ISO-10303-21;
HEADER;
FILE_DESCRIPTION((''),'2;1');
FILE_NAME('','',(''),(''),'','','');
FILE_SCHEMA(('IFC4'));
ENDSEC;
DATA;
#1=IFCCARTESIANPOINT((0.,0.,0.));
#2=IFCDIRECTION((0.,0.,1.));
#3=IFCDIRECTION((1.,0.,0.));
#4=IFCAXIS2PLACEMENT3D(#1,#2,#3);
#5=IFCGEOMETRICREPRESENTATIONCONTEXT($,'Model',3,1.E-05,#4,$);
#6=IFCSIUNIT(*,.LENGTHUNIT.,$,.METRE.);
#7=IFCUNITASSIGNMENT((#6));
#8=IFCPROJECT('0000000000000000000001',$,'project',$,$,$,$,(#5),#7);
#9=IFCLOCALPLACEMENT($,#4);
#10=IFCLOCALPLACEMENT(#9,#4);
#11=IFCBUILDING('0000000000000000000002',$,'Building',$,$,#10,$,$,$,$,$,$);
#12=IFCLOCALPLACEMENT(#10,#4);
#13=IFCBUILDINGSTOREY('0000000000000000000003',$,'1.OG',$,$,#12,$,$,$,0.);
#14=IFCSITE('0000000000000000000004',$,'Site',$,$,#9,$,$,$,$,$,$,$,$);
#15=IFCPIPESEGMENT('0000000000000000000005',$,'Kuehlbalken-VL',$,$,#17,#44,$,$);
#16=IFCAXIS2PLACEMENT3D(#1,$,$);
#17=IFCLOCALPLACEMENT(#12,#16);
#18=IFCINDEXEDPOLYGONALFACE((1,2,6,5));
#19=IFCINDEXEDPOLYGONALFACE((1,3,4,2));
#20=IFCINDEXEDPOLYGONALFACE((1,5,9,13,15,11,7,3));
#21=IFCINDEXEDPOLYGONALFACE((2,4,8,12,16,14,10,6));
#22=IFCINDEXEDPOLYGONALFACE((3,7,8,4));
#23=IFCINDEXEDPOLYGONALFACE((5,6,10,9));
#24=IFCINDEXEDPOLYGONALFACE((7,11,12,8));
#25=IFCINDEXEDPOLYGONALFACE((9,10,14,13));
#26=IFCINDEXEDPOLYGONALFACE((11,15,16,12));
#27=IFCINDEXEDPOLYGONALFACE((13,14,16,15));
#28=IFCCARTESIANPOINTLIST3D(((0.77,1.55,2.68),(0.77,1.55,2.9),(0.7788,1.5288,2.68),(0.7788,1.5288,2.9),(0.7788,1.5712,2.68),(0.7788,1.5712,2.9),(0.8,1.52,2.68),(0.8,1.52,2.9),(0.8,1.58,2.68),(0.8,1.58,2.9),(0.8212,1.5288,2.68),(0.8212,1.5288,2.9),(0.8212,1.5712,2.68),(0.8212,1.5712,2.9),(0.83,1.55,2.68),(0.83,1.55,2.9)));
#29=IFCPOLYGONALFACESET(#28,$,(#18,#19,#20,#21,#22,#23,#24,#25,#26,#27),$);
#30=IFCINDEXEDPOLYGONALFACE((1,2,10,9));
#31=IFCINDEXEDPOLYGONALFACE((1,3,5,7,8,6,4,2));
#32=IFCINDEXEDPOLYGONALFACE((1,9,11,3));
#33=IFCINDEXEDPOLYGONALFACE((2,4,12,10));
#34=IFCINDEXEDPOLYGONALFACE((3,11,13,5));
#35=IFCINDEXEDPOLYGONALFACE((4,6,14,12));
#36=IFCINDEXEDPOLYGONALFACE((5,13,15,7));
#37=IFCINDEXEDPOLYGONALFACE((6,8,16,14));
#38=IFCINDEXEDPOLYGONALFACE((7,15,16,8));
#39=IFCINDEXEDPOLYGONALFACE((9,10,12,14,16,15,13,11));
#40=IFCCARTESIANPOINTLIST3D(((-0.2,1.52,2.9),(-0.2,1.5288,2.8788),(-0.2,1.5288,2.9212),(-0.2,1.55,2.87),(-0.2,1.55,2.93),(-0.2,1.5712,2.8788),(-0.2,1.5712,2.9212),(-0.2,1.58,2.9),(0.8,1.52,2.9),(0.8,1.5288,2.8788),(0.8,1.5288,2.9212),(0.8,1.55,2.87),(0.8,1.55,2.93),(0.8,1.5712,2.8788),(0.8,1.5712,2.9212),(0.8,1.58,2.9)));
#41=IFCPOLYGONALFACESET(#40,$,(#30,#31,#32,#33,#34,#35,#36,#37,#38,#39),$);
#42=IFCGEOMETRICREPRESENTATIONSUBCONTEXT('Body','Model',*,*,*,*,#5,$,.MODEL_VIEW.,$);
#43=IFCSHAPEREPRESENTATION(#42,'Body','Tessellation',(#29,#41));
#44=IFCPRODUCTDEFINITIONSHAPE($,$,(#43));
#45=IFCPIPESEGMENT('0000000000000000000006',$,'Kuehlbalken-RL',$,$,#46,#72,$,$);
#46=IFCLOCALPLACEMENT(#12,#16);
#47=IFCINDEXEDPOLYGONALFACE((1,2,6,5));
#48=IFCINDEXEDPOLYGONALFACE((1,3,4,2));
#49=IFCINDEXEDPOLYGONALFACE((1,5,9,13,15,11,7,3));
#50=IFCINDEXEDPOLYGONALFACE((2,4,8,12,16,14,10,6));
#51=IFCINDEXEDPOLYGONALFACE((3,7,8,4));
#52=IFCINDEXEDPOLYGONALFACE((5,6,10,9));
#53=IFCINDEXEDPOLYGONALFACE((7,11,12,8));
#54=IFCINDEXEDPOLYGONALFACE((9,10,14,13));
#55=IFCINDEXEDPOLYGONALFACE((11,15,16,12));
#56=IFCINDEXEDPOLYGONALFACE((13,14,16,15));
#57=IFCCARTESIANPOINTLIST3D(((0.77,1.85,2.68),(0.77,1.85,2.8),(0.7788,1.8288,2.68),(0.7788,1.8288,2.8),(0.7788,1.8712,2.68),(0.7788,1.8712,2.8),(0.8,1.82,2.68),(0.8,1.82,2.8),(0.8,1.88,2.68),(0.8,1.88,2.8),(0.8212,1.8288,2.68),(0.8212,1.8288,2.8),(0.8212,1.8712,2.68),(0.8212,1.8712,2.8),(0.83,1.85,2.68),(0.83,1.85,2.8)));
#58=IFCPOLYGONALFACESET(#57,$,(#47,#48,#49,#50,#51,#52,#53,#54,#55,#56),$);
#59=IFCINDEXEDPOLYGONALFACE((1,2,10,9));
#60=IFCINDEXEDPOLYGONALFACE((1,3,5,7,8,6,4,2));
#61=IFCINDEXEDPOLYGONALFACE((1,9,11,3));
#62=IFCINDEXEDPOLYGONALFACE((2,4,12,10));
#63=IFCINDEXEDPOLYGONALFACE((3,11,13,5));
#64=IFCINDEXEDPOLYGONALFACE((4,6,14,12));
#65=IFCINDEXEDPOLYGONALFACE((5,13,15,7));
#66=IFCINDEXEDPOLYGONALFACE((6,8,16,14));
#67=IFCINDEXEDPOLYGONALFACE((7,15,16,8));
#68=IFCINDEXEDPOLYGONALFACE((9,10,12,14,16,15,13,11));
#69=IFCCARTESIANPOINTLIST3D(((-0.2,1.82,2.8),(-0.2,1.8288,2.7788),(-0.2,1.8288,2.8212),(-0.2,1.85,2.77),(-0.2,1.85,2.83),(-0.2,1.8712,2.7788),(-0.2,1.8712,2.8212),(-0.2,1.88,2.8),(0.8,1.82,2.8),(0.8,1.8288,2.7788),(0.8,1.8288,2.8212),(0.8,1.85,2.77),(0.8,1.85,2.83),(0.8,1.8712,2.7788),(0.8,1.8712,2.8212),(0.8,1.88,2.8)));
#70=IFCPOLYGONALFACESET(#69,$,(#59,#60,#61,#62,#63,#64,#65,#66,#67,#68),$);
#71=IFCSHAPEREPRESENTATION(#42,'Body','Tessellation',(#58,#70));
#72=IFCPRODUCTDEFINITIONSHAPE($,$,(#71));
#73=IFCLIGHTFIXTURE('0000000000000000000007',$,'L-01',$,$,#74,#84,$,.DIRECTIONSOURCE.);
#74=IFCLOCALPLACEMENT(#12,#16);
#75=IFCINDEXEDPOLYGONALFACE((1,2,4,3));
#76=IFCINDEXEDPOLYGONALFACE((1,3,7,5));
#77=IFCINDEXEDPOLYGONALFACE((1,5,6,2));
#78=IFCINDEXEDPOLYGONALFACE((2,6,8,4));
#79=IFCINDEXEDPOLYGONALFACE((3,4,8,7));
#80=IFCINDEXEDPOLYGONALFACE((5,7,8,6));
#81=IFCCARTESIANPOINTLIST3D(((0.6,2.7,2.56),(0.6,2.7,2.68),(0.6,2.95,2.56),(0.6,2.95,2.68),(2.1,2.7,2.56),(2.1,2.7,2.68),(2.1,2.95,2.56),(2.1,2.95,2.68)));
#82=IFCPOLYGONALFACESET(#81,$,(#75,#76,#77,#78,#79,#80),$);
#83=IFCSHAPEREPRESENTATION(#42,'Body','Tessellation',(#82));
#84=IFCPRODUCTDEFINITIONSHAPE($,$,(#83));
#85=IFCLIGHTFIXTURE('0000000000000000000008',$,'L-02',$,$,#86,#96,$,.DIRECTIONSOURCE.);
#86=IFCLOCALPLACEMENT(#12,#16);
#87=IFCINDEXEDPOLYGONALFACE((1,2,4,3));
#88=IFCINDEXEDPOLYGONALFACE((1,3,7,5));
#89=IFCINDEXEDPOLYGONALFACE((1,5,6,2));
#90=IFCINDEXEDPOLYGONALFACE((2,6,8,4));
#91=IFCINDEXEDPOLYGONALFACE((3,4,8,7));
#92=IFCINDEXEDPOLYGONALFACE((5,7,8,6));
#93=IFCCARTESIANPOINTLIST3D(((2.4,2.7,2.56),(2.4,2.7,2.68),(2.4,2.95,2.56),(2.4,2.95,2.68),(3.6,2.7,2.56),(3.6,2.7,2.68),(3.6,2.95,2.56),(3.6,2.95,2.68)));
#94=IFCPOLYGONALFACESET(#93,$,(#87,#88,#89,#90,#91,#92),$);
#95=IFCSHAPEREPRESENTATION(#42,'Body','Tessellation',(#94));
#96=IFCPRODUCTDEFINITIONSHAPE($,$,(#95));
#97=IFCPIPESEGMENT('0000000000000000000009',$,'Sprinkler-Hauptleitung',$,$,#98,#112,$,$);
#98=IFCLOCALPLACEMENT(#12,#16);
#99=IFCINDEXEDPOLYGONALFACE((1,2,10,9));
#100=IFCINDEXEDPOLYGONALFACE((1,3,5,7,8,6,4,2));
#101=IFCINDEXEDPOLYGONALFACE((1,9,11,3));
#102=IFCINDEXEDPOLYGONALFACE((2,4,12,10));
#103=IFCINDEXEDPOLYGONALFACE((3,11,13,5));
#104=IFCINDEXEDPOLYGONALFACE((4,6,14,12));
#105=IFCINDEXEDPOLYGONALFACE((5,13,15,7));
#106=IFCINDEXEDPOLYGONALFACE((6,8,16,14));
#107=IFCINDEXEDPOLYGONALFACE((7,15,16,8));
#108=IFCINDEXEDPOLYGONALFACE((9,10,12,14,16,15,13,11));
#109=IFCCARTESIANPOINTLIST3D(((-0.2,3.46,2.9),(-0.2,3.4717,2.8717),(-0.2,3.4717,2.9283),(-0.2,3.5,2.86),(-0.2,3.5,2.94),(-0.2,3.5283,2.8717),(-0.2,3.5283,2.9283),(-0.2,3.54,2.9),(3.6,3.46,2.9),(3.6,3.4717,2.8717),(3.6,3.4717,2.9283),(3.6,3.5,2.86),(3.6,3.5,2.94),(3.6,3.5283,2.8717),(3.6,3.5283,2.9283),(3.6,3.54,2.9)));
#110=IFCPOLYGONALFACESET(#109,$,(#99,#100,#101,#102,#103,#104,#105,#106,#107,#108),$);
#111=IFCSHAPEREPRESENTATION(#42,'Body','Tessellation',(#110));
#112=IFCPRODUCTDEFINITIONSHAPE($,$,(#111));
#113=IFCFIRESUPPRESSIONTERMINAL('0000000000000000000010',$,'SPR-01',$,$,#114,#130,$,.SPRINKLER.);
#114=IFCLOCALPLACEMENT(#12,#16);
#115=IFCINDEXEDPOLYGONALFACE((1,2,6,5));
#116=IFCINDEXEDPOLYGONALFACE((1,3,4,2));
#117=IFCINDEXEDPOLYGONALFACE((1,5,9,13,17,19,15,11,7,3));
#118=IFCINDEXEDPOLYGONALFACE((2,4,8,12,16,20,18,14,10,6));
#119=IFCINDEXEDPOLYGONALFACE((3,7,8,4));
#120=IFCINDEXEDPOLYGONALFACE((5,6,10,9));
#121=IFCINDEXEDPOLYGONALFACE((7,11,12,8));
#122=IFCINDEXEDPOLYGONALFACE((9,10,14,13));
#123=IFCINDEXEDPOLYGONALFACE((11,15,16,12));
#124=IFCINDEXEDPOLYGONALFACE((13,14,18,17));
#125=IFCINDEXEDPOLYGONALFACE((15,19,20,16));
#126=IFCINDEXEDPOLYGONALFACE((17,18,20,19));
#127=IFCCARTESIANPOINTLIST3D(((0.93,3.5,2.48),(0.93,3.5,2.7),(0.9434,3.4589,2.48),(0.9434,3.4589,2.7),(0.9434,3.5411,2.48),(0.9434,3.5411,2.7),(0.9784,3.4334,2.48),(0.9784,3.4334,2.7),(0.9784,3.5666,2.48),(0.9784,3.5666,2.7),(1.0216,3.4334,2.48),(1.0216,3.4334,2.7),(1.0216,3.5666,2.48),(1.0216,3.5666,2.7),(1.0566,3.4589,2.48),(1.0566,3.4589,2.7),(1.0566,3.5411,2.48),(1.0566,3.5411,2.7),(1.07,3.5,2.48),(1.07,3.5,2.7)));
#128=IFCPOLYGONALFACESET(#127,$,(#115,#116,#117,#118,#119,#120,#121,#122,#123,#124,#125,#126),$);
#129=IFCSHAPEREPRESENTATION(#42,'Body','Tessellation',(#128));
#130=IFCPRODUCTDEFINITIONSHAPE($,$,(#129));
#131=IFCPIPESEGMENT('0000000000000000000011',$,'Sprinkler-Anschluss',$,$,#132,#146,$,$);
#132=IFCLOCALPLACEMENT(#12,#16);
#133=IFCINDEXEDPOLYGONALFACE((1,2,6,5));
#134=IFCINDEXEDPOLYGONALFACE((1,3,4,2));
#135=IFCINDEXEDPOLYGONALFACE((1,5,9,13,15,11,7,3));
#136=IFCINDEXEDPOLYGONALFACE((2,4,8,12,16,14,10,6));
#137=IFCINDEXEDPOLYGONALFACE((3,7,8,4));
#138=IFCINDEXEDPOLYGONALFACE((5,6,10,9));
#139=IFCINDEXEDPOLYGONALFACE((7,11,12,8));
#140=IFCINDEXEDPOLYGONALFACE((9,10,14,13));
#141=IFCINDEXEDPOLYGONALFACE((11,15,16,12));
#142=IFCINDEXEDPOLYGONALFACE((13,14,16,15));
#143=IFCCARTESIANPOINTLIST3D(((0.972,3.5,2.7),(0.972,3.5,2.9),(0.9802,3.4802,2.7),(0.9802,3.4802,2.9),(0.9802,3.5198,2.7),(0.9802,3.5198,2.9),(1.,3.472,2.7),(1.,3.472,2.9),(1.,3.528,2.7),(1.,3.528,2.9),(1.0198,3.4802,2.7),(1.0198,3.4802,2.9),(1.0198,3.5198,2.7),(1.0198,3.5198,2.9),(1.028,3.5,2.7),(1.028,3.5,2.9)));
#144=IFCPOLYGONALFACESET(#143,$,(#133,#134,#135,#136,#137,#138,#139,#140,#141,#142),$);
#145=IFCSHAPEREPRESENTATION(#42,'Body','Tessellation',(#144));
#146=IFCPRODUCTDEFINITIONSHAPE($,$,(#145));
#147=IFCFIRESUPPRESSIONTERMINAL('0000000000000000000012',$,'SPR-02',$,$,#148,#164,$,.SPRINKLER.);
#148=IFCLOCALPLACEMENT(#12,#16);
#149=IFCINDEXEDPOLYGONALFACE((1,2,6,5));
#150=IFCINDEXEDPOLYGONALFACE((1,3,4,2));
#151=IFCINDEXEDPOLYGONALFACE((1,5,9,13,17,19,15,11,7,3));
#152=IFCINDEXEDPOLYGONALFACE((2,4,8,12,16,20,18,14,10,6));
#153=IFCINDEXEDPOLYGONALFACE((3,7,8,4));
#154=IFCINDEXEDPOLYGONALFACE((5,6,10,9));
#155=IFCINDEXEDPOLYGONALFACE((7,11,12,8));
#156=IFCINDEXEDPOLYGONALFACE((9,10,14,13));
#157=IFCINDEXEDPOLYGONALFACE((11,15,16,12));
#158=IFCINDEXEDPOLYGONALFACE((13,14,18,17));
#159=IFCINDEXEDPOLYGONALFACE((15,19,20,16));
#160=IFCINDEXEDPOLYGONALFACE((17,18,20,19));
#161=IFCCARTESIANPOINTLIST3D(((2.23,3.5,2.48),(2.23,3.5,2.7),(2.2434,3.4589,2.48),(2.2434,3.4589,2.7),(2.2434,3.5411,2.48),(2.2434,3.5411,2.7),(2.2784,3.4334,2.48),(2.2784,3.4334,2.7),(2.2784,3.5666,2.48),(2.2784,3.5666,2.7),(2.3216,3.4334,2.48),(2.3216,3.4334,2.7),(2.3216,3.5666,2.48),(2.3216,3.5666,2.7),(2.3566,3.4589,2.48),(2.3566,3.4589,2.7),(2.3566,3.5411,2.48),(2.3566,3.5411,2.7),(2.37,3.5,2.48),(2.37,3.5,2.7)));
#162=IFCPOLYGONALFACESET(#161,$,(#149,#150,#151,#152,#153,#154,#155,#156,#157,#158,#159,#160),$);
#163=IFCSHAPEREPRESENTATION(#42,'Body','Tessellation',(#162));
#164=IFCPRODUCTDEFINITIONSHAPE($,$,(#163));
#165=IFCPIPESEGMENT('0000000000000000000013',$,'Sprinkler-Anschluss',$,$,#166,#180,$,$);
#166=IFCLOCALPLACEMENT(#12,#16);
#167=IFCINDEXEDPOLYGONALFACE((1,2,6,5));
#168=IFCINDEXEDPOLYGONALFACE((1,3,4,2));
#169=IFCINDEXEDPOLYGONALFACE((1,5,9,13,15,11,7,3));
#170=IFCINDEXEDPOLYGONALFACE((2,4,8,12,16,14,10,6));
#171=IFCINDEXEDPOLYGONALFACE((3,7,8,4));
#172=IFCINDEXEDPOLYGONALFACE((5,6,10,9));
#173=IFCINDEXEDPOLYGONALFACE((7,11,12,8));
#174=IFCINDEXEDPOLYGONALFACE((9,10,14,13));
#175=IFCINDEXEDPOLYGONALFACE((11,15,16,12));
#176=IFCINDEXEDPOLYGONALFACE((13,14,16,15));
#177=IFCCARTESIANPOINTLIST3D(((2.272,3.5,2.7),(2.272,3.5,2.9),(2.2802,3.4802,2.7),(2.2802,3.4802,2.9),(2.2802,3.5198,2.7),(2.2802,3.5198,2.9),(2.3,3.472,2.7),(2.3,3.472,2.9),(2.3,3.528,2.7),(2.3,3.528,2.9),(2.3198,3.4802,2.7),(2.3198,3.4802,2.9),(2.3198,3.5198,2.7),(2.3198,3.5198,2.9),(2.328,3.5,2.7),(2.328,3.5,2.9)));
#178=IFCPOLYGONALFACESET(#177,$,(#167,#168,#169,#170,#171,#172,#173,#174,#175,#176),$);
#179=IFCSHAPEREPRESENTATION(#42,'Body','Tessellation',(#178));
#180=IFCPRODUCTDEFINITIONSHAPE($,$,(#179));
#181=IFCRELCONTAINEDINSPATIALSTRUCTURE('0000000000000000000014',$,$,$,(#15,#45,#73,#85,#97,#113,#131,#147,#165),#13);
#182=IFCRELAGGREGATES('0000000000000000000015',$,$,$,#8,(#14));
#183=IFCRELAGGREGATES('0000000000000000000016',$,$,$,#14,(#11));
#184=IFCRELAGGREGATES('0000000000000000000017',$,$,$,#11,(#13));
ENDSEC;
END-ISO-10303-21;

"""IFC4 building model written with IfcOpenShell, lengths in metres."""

from ifc_helpers import new_model, si_unit, frame, origin_with_axes, place, context, subcontext, project, spatial, polyline, outline, extrude, element, save


model = new_model("IFC4")

# Units and contexts
model_context = context("Model", 3, precision=1e-05, world=origin_with_axes())
body_context = subcontext(model_context, "Body", "Model", "MODEL_VIEW")
ifc_project = project(units=[si_unit("LENGTHUNIT", "METRE")], contexts=[model_context])

# Site, building, storey
site_placement = place(None, origin_with_axes())
site = spatial("IfcSite", under=ifc_project, at=site_placement, Name="Site")
building_placement = place(site_placement, origin_with_axes())
building = spatial("IfcBuilding", under=site, at=building_placement, Name="Building")
storey_placement = place(building_placement, origin_with_axes())
storey = spatial("IfcBuildingStorey", under=building, at=storey_placement, Name="1.OG", Elevation=0.0)

# Pipe segments
pipe_segment_1_placement = place(storey_placement, origin_with_axes())
element("IfcPipeSegment", 1, at=pipe_segment_1_placement, inside=storey, Name="Kuehlbalken-VL", context=body_context, shape_type="SweptSolid", body=[
    extrude(outline(polyline([(0.03, 0.0, 0.0), (0.0212, 0.0212, 0.0), (0.0, 0.03, 0.0), (-0.0212, 0.0212, 0.0), (-0.03, 0.0, 0.0), (-0.0212, -0.0212, 0.0), (0.0, -0.03, 0.0), (0.0212, -0.0212, 0.0), (0.03, 0.0, 0.0)])), frame((0.8, 1.55, 2.68), z_axis=(0.0, 0.0, 1.0), x_axis=(1.0, 0.0, 0.0)), (0.0, 0.0, 1.0), 0.22),
    extrude(outline(polyline([(0.03, 0.0, 0.0), (0.0212, 0.0212, 0.0), (0.0, 0.03, 0.0), (-0.0212, 0.0212, 0.0), (-0.03, 0.0, 0.0), (-0.0212, -0.0212, 0.0), (0.0, -0.03, 0.0), (0.0212, -0.0212, 0.0), (0.03, 0.0, 0.0)])), frame((0.8, 1.55, 2.9), z_axis=(-1.0, 0.0, 0.0), x_axis=(0.0, -1.0, 0.0)), (0.0, 0.0, 1.0), 1.0),
])
pipe_segment_2_placement = place(storey_placement, origin_with_axes())
element("IfcPipeSegment", 2, at=pipe_segment_2_placement, inside=storey, Name="Kuehlbalken-RL", context=body_context, shape_type="SweptSolid", body=[
    extrude(outline(polyline([(0.03, 0.0, 0.0), (0.0212, 0.0212, 0.0), (0.0, 0.03, 0.0), (-0.0212, 0.0212, 0.0), (-0.03, 0.0, 0.0), (-0.0212, -0.0212, 0.0), (0.0, -0.03, 0.0), (0.0212, -0.0212, 0.0), (0.03, 0.0, 0.0)])), frame((0.8, 1.85, 2.68), z_axis=(0.0, 0.0, 1.0), x_axis=(1.0, 0.0, 0.0)), (0.0, 0.0, 1.0), 0.12),
    extrude(outline(polyline([(0.03, 0.0, 0.0), (0.0212, 0.0212, 0.0), (0.0, 0.03, 0.0), (-0.0212, 0.0212, 0.0), (-0.03, 0.0, 0.0), (-0.0212, -0.0212, 0.0), (0.0, -0.03, 0.0), (0.0212, -0.0212, 0.0), (0.03, 0.0, 0.0)])), frame((0.8, 1.85, 2.8), z_axis=(-1.0, 0.0, 0.0), x_axis=(0.0, -1.0, 0.0)), (0.0, 0.0, 1.0), 1.0),
])

# Light fixtures
light_fixture_1_placement = place(storey_placement, origin_with_axes())
element("IfcLightFixture", 3, at=light_fixture_1_placement, inside=storey, Name="L-01", PredefinedType="DIRECTIONSOURCE", context=body_context, shape_type="SweptSolid", body=[
    extrude(outline(polyline([(0.6, 2.7, 0.0), (2.1, 2.7, 0.0), (2.1, 2.95, 0.0), (0.6, 2.95, 0.0), (0.6, 2.7, 0.0)])), frame((0.0, 0.0, 2.56), z_axis=(0.0, 0.0, 1.0), x_axis=(1.0, 0.0, 0.0)), (0.0, 0.0, 1.0), 0.12),
])
light_fixture_2_placement = place(storey_placement, origin_with_axes())
element("IfcLightFixture", 4, at=light_fixture_2_placement, inside=storey, Name="L-02", PredefinedType="DIRECTIONSOURCE", context=body_context, shape_type="SweptSolid", body=[
    extrude(outline(polyline([(2.4, 2.7, 0.0), (3.6, 2.7, 0.0), (3.6, 2.95, 0.0), (2.4, 2.95, 0.0), (2.4, 2.7, 0.0)])), frame((0.0, 0.0, 2.56), z_axis=(0.0, 0.0, 1.0), x_axis=(1.0, 0.0, 0.0)), (0.0, 0.0, 1.0), 0.12),
])

# Pipe segment
pipe_segment_3_placement = place(storey_placement, origin_with_axes())
element("IfcPipeSegment", 5, at=pipe_segment_3_placement, inside=storey, Name="Sprinkler-Hauptleitung", context=body_context, shape_type="SweptSolid", body=[
    extrude(outline(polyline([(0.04, 0.0, 0.0), (0.0283, 0.0283, 0.0), (0.0, 0.04, 0.0), (-0.0283, 0.0283, 0.0), (-0.04, 0.0, 0.0), (-0.0283, -0.0283, 0.0), (0.0, -0.04, 0.0), (0.0283, -0.0283, 0.0), (0.04, 0.0, 0.0)])), frame((-0.2, 3.5, 2.9), z_axis=(1.0, 0.0, 0.0), x_axis=(0.0, 1.0, 0.0)), (0.0, 0.0, 1.0), 3.8),
])

# Fire suppression terminal
fire_suppression_terminal_1_placement = place(storey_placement, origin_with_axes())
element("IfcFireSuppressionTerminal", 6, at=fire_suppression_terminal_1_placement, inside=storey, Name="SPR-01", PredefinedType="SPRINKLER", context=body_context, shape_type="SweptSolid", body=[
    extrude(outline(polyline([(0.07, 0.0, 0.0), (0.0566, 0.0411, 0.0), (0.0216, 0.0666, 0.0), (-0.0216, 0.0666, 0.0), (-0.0566, 0.0411, 0.0), (-0.07, 0.0, 0.0), (-0.0566, -0.0411, 0.0), (-0.0216, -0.0666, 0.0), (0.0216, -0.0666, 0.0), (0.0566, -0.0411, 0.0), (0.07, 0.0, 0.0)])), frame((1.0, 3.5, 2.48), z_axis=(0.0, 0.0, 1.0), x_axis=(1.0, 0.0, 0.0)), (0.0, 0.0, 1.0), 0.22),
])

# Pipe segment
pipe_segment_4_placement = place(storey_placement, origin_with_axes())
element("IfcPipeSegment", 7, at=pipe_segment_4_placement, inside=storey, Name="Sprinkler-Anschluss", context=body_context, shape_type="SweptSolid", body=[
    extrude(outline(polyline([(0.028, 0.0, 0.0), (0.0198, 0.0198, 0.0), (0.0, 0.028, 0.0), (-0.0198, 0.0198, 0.0), (-0.028, 0.0, 0.0), (-0.0198, -0.0198, 0.0), (0.0, -0.028, 0.0), (0.0198, -0.0198, 0.0), (0.028, 0.0, 0.0)])), frame((1.0, 3.5, 2.7), z_axis=(0.0, 0.0, 1.0), x_axis=(1.0, 0.0, 0.0)), (0.0, 0.0, 1.0), 0.2),
])

# Fire suppression terminal
fire_suppression_terminal_2_placement = place(storey_placement, origin_with_axes())
element("IfcFireSuppressionTerminal", 8, at=fire_suppression_terminal_2_placement, inside=storey, Name="SPR-02", PredefinedType="SPRINKLER", context=body_context, shape_type="SweptSolid", body=[
    extrude(outline(polyline([(0.07, 0.0, 0.0), (0.0566, 0.0411, 0.0), (0.0216, 0.0666, 0.0), (-0.0216, 0.0666, 0.0), (-0.0566, 0.0411, 0.0), (-0.07, 0.0, 0.0), (-0.0566, -0.0411, 0.0), (-0.0216, -0.0666, 0.0), (0.0216, -0.0666, 0.0), (0.0566, -0.0411, 0.0), (0.07, 0.0, 0.0)])), frame((2.3, 3.5, 2.48), z_axis=(0.0, 0.0, 1.0), x_axis=(1.0, 0.0, 0.0)), (0.0, 0.0, 1.0), 0.22),
])

# Pipe segment
pipe_segment_5_placement = place(storey_placement, origin_with_axes())
element("IfcPipeSegment", 9, at=pipe_segment_5_placement, inside=storey, Name="Sprinkler-Anschluss", context=body_context, shape_type="SweptSolid", body=[
    extrude(outline(polyline([(0.028, 0.0, 0.0), (0.0198, 0.0198, 0.0), (0.0, 0.028, 0.0), (-0.0198, 0.0198, 0.0), (-0.028, 0.0, 0.0), (-0.0198, -0.0198, 0.0), (0.0, -0.028, 0.0), (0.0198, -0.0198, 0.0), (0.028, 0.0, 0.0)])), frame((2.3, 3.5, 2.7), z_axis=(0.0, 0.0, 1.0), x_axis=(1.0, 0.0, 0.0)), (0.0, 0.0, 1.0), 0.2),
])

save(model, "model.ifc")
